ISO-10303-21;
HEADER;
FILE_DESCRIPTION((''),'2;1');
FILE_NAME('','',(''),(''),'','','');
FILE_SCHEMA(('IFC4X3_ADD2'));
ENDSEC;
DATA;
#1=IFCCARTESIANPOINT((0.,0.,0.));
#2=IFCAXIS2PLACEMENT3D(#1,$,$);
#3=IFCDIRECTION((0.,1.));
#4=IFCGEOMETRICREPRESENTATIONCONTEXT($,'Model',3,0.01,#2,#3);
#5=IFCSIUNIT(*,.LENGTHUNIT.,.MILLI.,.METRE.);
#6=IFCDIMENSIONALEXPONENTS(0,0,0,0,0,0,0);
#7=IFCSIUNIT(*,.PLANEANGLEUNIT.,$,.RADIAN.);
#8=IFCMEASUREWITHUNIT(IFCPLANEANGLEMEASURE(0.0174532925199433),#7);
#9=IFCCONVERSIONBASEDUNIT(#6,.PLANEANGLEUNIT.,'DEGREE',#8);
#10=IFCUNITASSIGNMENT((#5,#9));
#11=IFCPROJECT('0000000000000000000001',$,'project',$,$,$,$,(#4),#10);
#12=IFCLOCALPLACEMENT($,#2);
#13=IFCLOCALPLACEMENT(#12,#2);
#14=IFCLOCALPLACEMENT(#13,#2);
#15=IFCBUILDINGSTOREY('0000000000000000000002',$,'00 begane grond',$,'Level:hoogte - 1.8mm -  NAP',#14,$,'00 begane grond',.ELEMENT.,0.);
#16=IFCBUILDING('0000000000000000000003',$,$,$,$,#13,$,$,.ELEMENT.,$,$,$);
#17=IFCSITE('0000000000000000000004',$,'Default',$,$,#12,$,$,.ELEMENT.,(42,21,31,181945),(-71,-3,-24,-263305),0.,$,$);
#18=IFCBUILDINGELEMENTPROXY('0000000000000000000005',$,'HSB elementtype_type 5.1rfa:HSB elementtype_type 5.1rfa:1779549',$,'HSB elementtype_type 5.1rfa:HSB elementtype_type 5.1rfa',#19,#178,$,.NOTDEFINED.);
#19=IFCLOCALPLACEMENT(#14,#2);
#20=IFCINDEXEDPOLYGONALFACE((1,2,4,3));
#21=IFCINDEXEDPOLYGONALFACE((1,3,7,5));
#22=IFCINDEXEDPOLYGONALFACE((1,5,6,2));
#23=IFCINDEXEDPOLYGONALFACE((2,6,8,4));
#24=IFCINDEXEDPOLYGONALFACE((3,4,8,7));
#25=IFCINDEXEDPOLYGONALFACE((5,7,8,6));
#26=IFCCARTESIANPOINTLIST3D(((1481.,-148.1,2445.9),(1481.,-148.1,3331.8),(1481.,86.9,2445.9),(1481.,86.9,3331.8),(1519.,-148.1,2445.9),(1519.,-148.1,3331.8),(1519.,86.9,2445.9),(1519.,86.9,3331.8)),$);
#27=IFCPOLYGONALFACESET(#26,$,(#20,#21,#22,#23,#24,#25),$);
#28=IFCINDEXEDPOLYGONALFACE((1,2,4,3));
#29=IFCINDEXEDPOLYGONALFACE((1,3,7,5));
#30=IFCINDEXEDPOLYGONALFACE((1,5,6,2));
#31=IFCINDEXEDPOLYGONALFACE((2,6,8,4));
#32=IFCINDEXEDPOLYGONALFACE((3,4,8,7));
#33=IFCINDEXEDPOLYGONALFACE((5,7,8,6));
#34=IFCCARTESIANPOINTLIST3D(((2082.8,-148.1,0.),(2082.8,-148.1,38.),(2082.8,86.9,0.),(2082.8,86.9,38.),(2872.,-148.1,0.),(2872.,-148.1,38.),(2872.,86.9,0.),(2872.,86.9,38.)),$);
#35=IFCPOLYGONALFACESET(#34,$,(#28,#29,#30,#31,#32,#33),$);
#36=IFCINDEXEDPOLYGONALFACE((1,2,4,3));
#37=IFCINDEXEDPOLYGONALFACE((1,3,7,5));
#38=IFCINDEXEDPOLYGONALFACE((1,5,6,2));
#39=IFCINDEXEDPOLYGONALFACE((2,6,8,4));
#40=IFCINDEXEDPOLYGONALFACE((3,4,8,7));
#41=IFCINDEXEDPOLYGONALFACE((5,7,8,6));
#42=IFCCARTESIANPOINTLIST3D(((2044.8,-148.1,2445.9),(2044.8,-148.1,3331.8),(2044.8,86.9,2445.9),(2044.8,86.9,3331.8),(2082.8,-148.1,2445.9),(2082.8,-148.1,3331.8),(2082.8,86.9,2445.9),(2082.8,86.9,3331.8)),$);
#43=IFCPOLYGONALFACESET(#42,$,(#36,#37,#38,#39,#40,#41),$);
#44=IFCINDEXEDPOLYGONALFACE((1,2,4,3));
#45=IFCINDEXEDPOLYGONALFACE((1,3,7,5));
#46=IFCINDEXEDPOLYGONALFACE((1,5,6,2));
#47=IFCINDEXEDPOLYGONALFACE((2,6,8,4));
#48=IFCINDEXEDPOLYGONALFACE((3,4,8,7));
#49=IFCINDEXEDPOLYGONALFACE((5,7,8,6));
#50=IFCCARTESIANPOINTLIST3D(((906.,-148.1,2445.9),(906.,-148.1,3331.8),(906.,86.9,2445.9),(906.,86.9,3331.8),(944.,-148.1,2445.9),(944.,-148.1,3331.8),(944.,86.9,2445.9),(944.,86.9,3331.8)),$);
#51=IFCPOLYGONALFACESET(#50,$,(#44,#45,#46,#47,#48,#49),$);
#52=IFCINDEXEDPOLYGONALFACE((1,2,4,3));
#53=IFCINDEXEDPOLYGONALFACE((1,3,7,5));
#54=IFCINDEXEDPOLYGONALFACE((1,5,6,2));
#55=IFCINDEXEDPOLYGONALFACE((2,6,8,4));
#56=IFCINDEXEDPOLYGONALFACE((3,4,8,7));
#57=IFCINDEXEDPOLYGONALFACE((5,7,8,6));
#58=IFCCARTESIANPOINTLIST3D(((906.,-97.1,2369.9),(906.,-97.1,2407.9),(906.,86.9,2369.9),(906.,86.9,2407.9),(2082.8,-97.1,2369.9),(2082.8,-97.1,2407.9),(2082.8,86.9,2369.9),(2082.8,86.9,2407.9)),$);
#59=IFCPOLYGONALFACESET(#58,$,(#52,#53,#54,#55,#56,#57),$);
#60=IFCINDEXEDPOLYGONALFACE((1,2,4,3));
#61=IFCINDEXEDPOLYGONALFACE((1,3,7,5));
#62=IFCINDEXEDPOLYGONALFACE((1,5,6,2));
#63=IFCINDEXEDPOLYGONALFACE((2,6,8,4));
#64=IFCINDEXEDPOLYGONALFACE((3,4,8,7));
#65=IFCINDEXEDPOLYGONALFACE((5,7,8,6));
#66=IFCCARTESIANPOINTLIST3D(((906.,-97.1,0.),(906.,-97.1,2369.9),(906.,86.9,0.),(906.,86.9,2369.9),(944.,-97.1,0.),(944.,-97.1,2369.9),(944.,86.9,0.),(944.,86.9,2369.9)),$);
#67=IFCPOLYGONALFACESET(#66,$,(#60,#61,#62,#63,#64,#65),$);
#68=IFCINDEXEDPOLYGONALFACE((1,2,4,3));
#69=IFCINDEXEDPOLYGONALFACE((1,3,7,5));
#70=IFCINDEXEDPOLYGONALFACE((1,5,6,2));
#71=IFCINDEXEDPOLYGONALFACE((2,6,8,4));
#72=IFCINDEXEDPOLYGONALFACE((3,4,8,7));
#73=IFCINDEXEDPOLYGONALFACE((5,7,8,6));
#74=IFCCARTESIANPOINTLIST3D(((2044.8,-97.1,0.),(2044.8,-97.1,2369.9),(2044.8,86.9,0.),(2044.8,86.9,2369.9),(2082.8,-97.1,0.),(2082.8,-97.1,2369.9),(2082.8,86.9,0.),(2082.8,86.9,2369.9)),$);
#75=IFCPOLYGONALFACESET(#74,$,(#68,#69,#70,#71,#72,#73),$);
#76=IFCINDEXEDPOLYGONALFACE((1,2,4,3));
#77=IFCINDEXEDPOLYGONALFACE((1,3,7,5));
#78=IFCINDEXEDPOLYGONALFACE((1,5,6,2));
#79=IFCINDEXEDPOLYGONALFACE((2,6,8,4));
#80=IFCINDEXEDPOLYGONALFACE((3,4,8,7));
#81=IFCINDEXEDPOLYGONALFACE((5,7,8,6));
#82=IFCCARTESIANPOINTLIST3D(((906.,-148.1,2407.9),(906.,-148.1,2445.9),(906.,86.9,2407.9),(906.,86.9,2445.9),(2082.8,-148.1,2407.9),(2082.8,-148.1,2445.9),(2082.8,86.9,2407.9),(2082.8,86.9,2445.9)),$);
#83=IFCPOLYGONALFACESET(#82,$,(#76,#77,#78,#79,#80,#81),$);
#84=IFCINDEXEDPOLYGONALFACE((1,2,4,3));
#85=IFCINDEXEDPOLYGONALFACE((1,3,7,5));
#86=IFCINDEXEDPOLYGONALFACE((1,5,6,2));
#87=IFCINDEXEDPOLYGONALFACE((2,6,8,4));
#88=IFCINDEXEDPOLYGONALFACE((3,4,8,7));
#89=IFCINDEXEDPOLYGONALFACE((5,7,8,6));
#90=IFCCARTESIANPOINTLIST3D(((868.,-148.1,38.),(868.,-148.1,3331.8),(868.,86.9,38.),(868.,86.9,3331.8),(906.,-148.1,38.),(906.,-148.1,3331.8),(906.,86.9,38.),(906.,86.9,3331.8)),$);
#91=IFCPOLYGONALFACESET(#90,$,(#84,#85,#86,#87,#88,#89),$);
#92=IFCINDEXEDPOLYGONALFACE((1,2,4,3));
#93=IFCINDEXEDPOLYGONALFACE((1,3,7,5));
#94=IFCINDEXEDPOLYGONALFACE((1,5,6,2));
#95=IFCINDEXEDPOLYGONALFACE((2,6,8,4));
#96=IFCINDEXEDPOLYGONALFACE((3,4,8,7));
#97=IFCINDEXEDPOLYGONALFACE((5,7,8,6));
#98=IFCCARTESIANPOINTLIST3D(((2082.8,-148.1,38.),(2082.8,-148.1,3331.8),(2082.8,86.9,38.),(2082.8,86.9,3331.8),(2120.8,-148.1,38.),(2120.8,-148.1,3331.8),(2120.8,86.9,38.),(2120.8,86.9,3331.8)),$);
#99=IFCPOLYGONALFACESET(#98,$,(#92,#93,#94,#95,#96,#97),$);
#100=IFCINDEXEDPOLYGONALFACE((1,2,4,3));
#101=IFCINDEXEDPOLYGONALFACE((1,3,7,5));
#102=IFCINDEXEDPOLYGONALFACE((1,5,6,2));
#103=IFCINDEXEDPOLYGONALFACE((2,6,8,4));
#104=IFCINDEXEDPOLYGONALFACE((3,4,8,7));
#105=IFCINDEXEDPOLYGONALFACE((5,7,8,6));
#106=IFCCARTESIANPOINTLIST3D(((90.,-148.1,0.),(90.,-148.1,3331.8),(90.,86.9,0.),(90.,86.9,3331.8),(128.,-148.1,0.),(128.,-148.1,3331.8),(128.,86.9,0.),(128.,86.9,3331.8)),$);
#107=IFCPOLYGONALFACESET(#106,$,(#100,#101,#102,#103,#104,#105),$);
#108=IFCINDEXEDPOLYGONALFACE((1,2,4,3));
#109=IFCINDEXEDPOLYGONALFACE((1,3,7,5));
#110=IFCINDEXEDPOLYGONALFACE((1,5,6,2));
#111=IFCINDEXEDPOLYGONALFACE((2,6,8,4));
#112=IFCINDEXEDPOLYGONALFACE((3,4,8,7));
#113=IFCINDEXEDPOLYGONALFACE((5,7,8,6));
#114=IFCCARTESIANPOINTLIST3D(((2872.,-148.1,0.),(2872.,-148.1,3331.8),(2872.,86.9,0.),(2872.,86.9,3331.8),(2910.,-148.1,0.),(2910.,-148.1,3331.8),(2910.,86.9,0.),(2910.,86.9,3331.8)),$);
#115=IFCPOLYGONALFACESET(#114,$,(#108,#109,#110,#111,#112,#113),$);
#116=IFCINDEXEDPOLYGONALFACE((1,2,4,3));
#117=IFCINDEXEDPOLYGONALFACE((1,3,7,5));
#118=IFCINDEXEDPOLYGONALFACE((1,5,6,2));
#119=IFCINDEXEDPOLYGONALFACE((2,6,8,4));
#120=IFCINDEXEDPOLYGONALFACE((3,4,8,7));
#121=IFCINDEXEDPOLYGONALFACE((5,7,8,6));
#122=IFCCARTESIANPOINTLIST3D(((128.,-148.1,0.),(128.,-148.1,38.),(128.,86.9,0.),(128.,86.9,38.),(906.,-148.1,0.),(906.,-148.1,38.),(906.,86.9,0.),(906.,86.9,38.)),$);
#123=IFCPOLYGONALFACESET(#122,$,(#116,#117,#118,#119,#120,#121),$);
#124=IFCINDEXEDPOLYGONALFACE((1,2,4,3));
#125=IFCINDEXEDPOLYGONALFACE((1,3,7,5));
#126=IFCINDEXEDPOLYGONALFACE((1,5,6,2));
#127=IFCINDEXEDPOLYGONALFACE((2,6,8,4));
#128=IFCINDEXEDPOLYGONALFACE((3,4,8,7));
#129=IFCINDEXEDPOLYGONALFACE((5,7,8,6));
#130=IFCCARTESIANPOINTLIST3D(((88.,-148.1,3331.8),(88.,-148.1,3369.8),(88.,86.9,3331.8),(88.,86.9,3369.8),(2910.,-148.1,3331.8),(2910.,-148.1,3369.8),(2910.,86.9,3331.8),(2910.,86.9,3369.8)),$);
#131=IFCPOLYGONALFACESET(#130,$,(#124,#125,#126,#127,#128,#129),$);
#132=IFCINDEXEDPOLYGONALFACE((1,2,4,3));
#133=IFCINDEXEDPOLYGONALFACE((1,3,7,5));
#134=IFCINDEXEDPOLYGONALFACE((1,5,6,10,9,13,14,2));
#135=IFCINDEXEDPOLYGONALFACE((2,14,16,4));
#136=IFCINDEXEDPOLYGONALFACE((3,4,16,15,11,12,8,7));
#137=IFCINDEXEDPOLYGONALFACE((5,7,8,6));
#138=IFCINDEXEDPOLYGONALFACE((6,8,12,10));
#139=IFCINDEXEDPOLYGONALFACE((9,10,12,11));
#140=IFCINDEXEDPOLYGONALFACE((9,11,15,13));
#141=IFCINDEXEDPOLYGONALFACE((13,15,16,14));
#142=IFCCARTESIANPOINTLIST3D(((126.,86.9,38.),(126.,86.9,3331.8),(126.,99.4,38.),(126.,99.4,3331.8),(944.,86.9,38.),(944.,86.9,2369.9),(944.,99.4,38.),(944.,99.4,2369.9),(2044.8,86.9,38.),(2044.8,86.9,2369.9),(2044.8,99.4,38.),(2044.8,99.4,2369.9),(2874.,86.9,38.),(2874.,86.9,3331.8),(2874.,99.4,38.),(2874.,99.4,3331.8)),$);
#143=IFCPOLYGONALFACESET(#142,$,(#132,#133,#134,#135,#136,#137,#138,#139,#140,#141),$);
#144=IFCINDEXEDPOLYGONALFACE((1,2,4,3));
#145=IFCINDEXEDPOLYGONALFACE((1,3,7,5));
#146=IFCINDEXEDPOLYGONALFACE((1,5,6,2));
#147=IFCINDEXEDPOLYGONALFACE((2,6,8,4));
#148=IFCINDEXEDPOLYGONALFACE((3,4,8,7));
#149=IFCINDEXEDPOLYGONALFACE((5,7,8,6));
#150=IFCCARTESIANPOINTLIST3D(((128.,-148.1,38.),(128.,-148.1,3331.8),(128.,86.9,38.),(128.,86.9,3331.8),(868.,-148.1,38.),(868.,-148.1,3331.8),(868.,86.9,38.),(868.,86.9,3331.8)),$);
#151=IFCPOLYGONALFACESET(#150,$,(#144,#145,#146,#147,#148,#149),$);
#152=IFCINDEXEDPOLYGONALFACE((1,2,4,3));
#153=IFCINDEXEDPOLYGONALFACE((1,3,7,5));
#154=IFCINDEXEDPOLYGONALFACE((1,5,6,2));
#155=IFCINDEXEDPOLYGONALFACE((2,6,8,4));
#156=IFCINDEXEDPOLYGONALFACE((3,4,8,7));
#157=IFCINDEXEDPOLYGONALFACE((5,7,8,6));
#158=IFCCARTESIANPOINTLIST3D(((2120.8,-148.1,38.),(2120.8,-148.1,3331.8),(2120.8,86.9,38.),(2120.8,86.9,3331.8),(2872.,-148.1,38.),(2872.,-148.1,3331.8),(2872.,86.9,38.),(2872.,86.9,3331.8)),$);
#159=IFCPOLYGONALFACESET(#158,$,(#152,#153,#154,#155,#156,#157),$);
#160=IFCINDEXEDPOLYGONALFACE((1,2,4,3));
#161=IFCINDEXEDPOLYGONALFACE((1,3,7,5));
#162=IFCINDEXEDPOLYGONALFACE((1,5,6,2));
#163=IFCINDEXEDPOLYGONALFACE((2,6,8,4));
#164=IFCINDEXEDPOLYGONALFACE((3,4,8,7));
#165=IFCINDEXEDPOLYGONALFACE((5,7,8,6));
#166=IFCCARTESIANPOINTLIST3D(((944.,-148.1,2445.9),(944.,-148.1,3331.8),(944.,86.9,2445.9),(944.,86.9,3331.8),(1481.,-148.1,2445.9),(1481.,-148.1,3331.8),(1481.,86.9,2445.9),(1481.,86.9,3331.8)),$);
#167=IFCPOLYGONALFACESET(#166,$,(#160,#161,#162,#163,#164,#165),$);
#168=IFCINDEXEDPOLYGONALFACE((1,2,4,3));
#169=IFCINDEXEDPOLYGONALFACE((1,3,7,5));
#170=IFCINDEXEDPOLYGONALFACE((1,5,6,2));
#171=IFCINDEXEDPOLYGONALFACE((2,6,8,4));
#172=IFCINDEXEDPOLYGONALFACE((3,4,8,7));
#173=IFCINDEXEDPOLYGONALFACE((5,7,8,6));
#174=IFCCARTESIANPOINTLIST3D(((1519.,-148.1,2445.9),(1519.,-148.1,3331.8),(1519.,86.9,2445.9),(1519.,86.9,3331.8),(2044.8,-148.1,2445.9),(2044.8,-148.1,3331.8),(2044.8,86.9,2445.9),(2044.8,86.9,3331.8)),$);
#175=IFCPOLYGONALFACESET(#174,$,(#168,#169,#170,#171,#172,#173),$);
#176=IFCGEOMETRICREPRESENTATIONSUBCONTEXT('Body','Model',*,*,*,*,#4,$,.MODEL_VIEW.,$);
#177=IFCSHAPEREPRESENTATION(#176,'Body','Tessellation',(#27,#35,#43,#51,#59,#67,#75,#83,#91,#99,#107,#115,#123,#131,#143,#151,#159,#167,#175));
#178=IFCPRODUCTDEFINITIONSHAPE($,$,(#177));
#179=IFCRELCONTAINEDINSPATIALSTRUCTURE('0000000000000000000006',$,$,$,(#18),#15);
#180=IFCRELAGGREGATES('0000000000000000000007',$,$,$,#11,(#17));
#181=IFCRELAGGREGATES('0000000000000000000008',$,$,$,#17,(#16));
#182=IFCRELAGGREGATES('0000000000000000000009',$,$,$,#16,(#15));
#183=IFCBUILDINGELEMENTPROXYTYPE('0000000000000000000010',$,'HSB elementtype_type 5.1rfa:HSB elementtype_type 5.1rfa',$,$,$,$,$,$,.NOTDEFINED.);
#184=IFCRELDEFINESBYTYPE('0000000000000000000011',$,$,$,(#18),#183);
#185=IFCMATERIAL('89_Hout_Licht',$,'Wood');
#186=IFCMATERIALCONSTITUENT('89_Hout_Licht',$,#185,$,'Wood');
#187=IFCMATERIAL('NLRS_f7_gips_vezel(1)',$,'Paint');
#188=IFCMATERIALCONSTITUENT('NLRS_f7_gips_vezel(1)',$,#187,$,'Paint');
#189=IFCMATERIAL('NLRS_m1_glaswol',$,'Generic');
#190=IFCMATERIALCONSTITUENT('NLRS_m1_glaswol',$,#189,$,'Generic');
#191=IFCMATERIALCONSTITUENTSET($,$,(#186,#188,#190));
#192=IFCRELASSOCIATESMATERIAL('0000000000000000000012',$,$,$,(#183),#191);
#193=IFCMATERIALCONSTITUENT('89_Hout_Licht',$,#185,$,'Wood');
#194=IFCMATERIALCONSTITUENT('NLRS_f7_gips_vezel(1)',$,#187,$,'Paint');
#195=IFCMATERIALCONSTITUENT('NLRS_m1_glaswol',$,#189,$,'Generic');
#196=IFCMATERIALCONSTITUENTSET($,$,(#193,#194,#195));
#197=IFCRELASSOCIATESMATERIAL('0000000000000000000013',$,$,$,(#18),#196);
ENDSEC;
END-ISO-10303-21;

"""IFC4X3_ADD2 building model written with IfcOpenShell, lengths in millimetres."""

from ifc_helpers import new_model, entity, si_unit, converted_unit, direction, frame, frame_2d, origin, origin_2d_with_axis, place, context, subcontext, project, spatial, polyline, rectangle, outline, extrude, source, transform, mapped, material, constituent, constituent_set, type_object, type_shapes, element, save


model = new_model("IFC4X3_ADD2")

# Units and contexts
model_context = context("Model", 3, precision=0.01, world=origin(), true_north=direction((0.0, 1.0)))
body_context = subcontext(model_context, "Body", "Model", "MODEL_VIEW")
ifc_project = project(units=[si_unit("LENGTHUNIT", "METRE", prefix="MILLI"), converted_unit("PLANEANGLEUNIT", "DEGREE", entity("IfcPlaneAngleMeasure", 0.0174532925199433), si_unit("PLANEANGLEUNIT", "RADIAN"), dimensions=[0, 0, 0, 0, 0, 0, 0])], contexts=[model_context])

# Site, building, storey
site_placement = place(None, origin())
site = spatial("IfcSite", under=ifc_project, at=site_placement, Name="Default", CompositionType="ELEMENT", RefLatitude=(42, 21, 31, 181945), RefLongitude=(-71, -3, -24, -263305), RefElevation=0.0)
building_placement = place(site_placement, origin())
building = spatial("IfcBuilding", under=site, at=building_placement, CompositionType="ELEMENT")
storey_placement = place(building_placement, origin())
storey = spatial("IfcBuildingStorey", under=building, at=storey_placement, Name="00 begane grond", ObjectType="Level:hoogte - 1.8mm -  NAP", LongName="00 begane grond", CompositionType="ELEMENT", Elevation=0.0)

# Shared definitions
ifc_material_1 = material(Name="NLRS_m1_glaswol", Category="Generic")

# Shared definitions
ifc_material_2 = material(Name="NLRS_f7_gips_vezel(1)", Category="Paint")

# Building element proxy
ifc_material_3 = material(Name="89_Hout_Licht", Category="Wood")
ifc_constituent_1 = constituent(ifc_material_3, Name="89_Hout_Licht", Category="Wood")
ifc_constituent_2 = constituent(ifc_material_2, Name="NLRS_f7_gips_vezel(1)", Category="Paint")
ifc_constituent_3 = constituent(ifc_material_1, Name="NLRS_m1_glaswol", Category="Generic")
ifc_constituent_set_1 = constituent_set(constituents=[ifc_constituent_1, ifc_constituent_2, ifc_constituent_3])
ifc_constituent_4 = constituent(ifc_material_3, Name="89_Hout_Licht", Category="Wood")
ifc_constituent_5 = constituent(ifc_material_2, Name="NLRS_f7_gips_vezel(1)", Category="Paint")
ifc_constituent_6 = constituent(ifc_material_1, Name="NLRS_m1_glaswol", Category="Generic")
ifc_constituent_set_2 = constituent_set(constituents=[ifc_constituent_4, ifc_constituent_5, ifc_constituent_6])
building_element_proxy_type_1 = type_object("IfcBuildingElementProxyType", Name="HSB elementtype_type 5.1rfa:HSB elementtype_type 5.1rfa", PredefinedType="NOTDEFINED", material=ifc_constituent_set_2)
shared_shape_1 = source(origin(), body_context, "Body", "SweptSolid", [
    extrude(rectangle(XDim=235.0, YDim=38.0, at=frame_2d((0.0, 0.0), x_axis=(1.0, 0.0))), frame((1500.0, -30.6, 2445.9), z_axis=(0.0, 0.0, 1.0), x_axis=(0.0, 1.0, 0.0)), (0.0, 0.0, 1.0), 885.9),
    extrude(rectangle(XDim=235.0, YDim=789.1, at=origin_2d_with_axis()), frame((2477.4, -30.6, 0.0), z_axis=(0.0, 0.0, 1.0), x_axis=(0.0, 1.0, 0.0)), (0.0, 0.0, 1.0), 38.0),
    extrude(rectangle(XDim=235.0, YDim=38.0, at=origin_2d_with_axis()), frame((2063.8, -30.6, 2445.9), z_axis=(0.0, 0.0, 1.0), x_axis=(0.0, 1.0, 0.0)), (0.0, 0.0, 1.0), 885.9),
    extrude(rectangle(XDim=235.0, YDim=38.0, at=origin_2d_with_axis()), frame((925.0, -30.6, 2445.9), z_axis=(0.0, 0.0, 1.0), x_axis=(0.0, 1.0, 0.0)), (0.0, 0.0, 1.0), 885.9),
    extrude(rectangle(XDim=184.0, YDim=1176.9, at=frame_2d((0.0, 0.0), x_axis=(1.0, 0.0))), frame((1494.4, -5.1, 2369.9), z_axis=(0.0, 0.0, 1.0), x_axis=(0.0, 1.0, 0.0)), (0.0, 0.0, 1.0), 38.0),
    extrude(rectangle(XDim=184.0, YDim=38.0, at=frame_2d((0.0, 0.0), x_axis=(1.0, 0.0))), frame((925.0, -5.1, 0.0), z_axis=(0.0, 0.0, 1.0), x_axis=(0.0, 1.0, 0.0)), (0.0, 0.0, 1.0), 2369.9),
    extrude(rectangle(XDim=184.0, YDim=38.0, at=frame_2d((0.0, 0.0), x_axis=(1.0, 0.0))), frame((2063.8, -5.1, 0.0), z_axis=(0.0, 0.0, 1.0), x_axis=(0.0, 1.0, 0.0)), (0.0, 0.0, 1.0), 2369.9),
    extrude(rectangle(XDim=235.0, YDim=1176.9, at=frame_2d((0.0, 0.0), x_axis=(1.0, 0.0))), frame((1494.4, -30.6, 2407.9), z_axis=(0.0, 0.0, 1.0), x_axis=(0.0, 1.0, 0.0)), (0.0, 0.0, 1.0), 38.0),
    extrude(rectangle(XDim=235.0, YDim=38.0, at=frame_2d((0.0, 0.0), x_axis=(1.0, 0.0))), frame((887.0, -30.6, 38.0), z_axis=(0.0, 0.0, 1.0), x_axis=(0.0, 1.0, 0.0)), (0.0, 0.0, 1.0), 3293.8),
    extrude(rectangle(XDim=235.0, YDim=38.0, at=origin_2d_with_axis()), frame((2101.8, -30.6, 38.0), z_axis=(0.0, 0.0, 1.0), x_axis=(0.0, 1.0, 0.0)), (0.0, 0.0, 1.0), 3293.8),
    extrude(rectangle(XDim=235.0, YDim=38.0, at=frame_2d((0.0, 0.0), x_axis=(1.0, 0.0))), frame((109.0, -30.6, 0.0), z_axis=(0.0, 0.0, 1.0), x_axis=(0.0, 1.0, 0.0)), (0.0, 0.0, 1.0), 3331.8),
    extrude(rectangle(XDim=235.0, YDim=38.0, at=frame_2d((-23.5, -3.4), x_axis=(1.0, 0.0))), frame((2887.6, -7.1, 0.0), z_axis=(0.0, 0.0, 1.0), x_axis=(0.0, 1.0, 0.0)), (0.0, 0.0, 1.0), 3331.8),
    extrude(rectangle(XDim=235.0, YDim=778.0, at=origin_2d_with_axis()), frame((517.0, -30.6, 0.0), z_axis=(0.0, 0.0, 1.0), x_axis=(0.0, 1.0, 0.0)), (0.0, 0.0, 1.0), 38.0),
    extrude(rectangle(XDim=235.0, YDim=2822.0, at=origin_2d_with_axis()), frame((1499.0, -30.6, 3331.8), z_axis=(0.0, 0.0, 1.0), x_axis=(0.0, 1.0, 0.0)), (0.0, 0.0, 1.0), 38.0),
    extrude(outline(polyline([(-1887.4, -1376.8), (1406.4, -1376.8), (1406.4, -547.7), (-925.5, -547.7), (-925.5, 553.2), (1406.4, 553.2), (1406.4, 1371.2), (-1887.4, 1371.2), (-1887.4, -1376.8)])), frame((1497.2, 86.9, 1444.4), z_axis=(0.0, 1.0, 0.0), x_axis=(0.0, 0.0, -1.0)), (0.0, 0.0, 1.0), 12.5),
    extrude(rectangle(XDim=235.0, YDim=740.0, at=frame_2d((0.0, 0.0), x_axis=(1.0, 0.0))), frame((498.0, -30.6, 38.0), z_axis=(0.0, 0.0, 1.0), x_axis=(0.0, 1.0, 0.0)), (0.0, 0.0, 1.0), 3293.8),
    extrude(rectangle(XDim=235.0, YDim=751.1, at=frame_2d((0.0, 0.0), x_axis=(1.0, 0.0))), frame((2496.4, -30.6, 38.0), z_axis=(0.0, 0.0, 1.0), x_axis=(0.0, 1.0, 0.0)), (0.0, 0.0, 1.0), 3293.8),
    extrude(rectangle(XDim=235.0, YDim=537.0, at=frame_2d((0.0, 0.0), x_axis=(1.0, 0.0))), frame((1212.5, -30.6, 2445.9), z_axis=(0.0, 0.0, 1.0), x_axis=(0.0, 1.0, 0.0)), (0.0, 0.0, 1.0), 885.9),
    extrude(rectangle(XDim=235.0, YDim=525.9, at=origin_2d_with_axis()), frame((1781.9, -30.6, 2445.9), z_axis=(0.0, 0.0, 1.0), x_axis=(0.0, 1.0, 0.0)), (0.0, 0.0, 1.0), 885.9),
])
type_shapes(building_element_proxy_type_1, [shared_shape_1])
proxy_1_placement = place(storey_placement, origin())
element("IfcBuildingElementProxy", 1, at=proxy_1_placement, inside=storey, type_object=building_element_proxy_type_1, material=ifc_constituent_set_1, Name="HSB elementtype_type 5.1rfa:HSB elementtype_type 5.1rfa:1779549", ObjectType="HSB elementtype_type 5.1rfa:HSB elementtype_type 5.1rfa", PredefinedType="NOTDEFINED", context=body_context, shape_type="MappedRepresentation", body=[
    mapped(shared_shape_1, transform((0.0, 0.0, 0.0), scale=1.0)),
])

save(model, "model.ifc")
